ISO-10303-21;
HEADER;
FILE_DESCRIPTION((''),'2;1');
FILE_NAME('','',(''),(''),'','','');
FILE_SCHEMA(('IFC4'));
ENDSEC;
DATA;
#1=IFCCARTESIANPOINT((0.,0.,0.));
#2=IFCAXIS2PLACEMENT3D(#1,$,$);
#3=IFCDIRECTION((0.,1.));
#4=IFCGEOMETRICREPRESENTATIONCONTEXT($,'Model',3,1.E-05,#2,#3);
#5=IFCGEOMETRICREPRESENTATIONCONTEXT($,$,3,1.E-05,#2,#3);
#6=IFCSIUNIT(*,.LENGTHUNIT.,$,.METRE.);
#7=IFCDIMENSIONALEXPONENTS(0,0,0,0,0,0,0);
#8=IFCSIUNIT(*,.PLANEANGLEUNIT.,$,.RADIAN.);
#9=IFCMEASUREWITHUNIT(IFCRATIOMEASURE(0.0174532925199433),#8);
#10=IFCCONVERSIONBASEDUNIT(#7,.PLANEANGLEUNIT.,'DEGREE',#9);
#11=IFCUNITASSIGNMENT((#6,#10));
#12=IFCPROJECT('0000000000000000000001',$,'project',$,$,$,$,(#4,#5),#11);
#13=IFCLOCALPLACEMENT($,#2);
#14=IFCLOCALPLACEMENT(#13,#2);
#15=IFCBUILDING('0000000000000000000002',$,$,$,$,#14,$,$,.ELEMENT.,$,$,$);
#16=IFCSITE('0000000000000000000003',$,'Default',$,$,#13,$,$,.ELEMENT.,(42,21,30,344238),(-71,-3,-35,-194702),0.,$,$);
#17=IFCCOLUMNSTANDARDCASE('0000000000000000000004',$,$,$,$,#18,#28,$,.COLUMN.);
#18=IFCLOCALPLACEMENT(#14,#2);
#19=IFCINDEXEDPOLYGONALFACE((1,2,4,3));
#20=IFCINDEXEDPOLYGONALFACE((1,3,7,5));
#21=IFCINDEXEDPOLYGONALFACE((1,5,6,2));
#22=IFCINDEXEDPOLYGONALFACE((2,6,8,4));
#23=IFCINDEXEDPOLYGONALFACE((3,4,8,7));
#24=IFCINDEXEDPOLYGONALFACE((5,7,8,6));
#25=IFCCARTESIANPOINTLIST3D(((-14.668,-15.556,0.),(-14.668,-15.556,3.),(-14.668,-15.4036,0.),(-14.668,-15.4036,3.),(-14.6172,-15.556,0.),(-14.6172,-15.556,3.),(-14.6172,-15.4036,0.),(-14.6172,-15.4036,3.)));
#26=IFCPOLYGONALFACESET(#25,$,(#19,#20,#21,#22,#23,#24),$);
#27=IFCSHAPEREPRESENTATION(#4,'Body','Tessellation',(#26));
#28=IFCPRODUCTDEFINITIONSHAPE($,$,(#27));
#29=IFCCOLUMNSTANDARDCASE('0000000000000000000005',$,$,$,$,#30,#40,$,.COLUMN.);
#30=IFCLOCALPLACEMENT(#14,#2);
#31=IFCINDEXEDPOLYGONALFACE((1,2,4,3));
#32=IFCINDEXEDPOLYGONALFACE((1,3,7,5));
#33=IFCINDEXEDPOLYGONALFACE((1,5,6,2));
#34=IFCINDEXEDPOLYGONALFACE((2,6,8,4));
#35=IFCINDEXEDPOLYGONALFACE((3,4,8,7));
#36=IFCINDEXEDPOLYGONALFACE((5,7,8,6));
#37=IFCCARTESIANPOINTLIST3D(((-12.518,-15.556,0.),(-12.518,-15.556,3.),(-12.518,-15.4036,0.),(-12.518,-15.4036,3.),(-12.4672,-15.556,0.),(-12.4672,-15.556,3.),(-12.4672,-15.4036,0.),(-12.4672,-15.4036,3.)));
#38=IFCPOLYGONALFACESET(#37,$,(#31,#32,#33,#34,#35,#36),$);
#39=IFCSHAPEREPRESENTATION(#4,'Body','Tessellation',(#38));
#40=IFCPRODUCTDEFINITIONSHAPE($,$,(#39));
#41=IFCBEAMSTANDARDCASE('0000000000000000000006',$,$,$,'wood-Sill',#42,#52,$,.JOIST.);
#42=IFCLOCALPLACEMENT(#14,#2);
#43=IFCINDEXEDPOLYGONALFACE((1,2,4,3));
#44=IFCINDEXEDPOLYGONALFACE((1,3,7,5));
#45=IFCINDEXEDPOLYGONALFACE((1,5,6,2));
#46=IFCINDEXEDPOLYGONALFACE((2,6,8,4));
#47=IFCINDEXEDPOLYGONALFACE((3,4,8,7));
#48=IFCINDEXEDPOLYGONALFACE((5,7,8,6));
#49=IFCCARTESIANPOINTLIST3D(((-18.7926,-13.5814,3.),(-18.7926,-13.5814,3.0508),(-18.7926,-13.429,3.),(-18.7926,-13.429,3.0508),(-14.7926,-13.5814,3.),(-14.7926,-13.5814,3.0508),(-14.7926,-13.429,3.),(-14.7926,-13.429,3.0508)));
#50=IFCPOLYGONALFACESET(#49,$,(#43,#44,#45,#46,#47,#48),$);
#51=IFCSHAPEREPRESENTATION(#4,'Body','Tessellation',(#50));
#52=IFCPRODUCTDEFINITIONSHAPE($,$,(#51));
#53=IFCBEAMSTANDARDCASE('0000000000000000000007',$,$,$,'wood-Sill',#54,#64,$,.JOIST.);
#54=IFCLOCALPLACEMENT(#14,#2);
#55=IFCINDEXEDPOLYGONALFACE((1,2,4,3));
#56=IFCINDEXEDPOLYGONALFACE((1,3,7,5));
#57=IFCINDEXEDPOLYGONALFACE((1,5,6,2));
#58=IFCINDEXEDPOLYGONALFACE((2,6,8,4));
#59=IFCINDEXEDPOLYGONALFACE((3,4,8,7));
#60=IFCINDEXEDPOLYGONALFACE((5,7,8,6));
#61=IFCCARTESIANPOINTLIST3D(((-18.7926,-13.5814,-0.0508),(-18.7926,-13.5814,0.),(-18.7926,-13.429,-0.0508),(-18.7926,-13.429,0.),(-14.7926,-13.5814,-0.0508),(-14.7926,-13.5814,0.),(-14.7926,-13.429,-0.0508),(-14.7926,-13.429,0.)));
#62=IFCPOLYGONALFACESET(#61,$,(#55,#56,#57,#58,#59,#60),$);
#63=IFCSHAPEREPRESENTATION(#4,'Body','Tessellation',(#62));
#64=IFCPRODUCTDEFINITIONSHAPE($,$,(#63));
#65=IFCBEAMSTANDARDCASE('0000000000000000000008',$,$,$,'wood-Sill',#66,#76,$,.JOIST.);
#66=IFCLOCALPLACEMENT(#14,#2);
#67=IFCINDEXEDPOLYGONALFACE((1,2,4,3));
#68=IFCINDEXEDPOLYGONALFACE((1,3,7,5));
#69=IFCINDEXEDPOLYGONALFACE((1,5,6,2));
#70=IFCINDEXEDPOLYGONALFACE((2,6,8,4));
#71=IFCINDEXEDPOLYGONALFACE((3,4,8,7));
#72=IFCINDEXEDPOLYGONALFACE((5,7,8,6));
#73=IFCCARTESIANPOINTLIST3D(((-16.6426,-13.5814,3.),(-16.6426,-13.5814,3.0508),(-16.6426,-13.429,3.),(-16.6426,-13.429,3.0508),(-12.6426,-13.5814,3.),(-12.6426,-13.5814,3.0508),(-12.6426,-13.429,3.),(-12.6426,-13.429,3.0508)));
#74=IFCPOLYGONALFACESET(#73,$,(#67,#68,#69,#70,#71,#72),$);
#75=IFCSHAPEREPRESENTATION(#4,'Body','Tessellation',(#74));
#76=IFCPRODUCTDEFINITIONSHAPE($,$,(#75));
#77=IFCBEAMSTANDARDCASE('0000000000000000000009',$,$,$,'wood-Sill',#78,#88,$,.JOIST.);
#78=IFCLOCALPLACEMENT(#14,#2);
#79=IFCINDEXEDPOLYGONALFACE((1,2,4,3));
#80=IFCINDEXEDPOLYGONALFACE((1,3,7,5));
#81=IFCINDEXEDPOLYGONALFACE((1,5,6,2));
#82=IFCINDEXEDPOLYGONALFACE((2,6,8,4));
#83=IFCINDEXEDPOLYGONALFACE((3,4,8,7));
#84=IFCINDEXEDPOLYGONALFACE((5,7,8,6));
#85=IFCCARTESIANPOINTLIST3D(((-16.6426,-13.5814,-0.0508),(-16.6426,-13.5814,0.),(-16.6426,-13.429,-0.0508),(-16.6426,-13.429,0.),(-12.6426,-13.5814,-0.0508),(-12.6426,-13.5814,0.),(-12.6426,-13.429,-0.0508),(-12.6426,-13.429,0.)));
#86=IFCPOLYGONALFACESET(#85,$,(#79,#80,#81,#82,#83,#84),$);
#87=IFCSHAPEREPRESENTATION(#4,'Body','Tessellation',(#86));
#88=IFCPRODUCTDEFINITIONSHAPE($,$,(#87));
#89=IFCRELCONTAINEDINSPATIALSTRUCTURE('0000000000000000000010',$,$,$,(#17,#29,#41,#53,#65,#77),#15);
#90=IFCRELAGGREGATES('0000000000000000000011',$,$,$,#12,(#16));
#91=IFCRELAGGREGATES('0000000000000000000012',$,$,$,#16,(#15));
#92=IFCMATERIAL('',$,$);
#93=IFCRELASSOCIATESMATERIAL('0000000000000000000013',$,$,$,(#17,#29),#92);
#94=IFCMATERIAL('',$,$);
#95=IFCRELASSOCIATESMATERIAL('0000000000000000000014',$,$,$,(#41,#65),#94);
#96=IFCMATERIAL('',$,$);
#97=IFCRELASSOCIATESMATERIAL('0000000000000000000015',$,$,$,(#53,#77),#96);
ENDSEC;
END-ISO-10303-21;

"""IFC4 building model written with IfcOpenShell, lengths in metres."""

from ifc_helpers import new_model, entity, si_unit, converted_unit, direction, frame, origin, place, context, project, spatial, rectangle, extrude, material, element, save


model = new_model("IFC4")

# Units and contexts
model_context = context("Model", 3, precision=1e-05, world=origin(), true_north=direction((0.0, 1.0)))
context_of_model = context(None, 3, precision=1e-05, world=origin(), true_north=direction((0.0, 1.0)))
ifc_project = project(units=[si_unit("LENGTHUNIT", "METRE"), converted_unit("PLANEANGLEUNIT", "DEGREE", entity("IfcRatioMeasure", 0.0174532925199433), si_unit("PLANEANGLEUNIT", "RADIAN"), dimensions=[0, 0, 0, 0, 0, 0, 0])], contexts=[model_context, context_of_model])

# Site, building
site_placement = place(None, origin())
site = spatial("IfcSite", under=ifc_project, at=site_placement, Name="Default", CompositionType="ELEMENT", RefLatitude=(42, 21, 30, 344238), RefLongitude=(-71, -3, -35, -194702), RefElevation=0.0)
building_placement = place(site_placement, origin())
building = spatial("IfcBuilding", under=site, at=building_placement, CompositionType="ELEMENT")

# Columns
ifc_material_1 = material(Name="")
placement_1 = place(building_placement, origin())
placement_2 = place(placement_1, frame((-14.6426, -15.5052, 0.0), z_axis=(0.0, 0.0, 1.0), x_axis=(0.0, 1.0, 0.0)))
for number, where, z_axis, x_axis in (
    (1, (0.0254, 0.0, 0.0), (0.0, 0.0, 1.0), (0.0, 1.0, 0.0)),
):
    element("IfcColumnStandardCase", number, at=place(placement_2, frame(where, z_axis=z_axis, x_axis=x_axis)), inside=building, material=ifc_material_1, PredefinedType="COLUMN", context=model_context, shape_type="SweptSolid", body=[
        extrude(rectangle(XDim=0.0508, YDim=0.1524), origin(), (0.0, 0.0, 1.0), 3.0),
    ])
placement_3 = place(placement_1, frame((-12.4926, -15.5052, 0.0), z_axis=(0.0, 0.0, 1.0), x_axis=(0.0, 1.0, 0.0)))
for number, where, z_axis, x_axis in (
    (2, (0.0254, 0.0, 0.0), (0.0, 0.0, 1.0), (0.0, 1.0, 0.0)),
):
    element("IfcColumnStandardCase", number, at=place(placement_3, frame(where, z_axis=z_axis, x_axis=x_axis)), inside=building, material=ifc_material_1, PredefinedType="COLUMN", context=model_context, shape_type="SweptSolid", body=[
        extrude(rectangle(XDim=0.0508, YDim=0.1524), origin(), (0.0, 0.0, 1.0), 3.0),
    ])

# Beams
ifc_material_2 = material(Name="")
placement_4 = place(placement_1, frame((-16.7926, -15.5052, 0.0), z_axis=(0.0, 0.0, 1.0), x_axis=(0.0, 1.0, 0.0)))
beam_1_placement = place(placement_4, frame((2.0, 0.0, 3.0), z_axis=(0.0, 0.0, 1.0), x_axis=(0.0, 1.0, 0.0)))
element("IfcBeamStandardCase", 3, at=beam_1_placement, inside=building, material=ifc_material_2, ObjectType="wood-Sill", PredefinedType="JOIST", context=model_context, shape_type="SweptSolid", body=[
    extrude(rectangle(XDim=4.0, YDim=0.1524), origin(), (0.0, 0.0, 1.0), 0.0508),
])
ifc_material_3 = material(Name="")
beam_2_placement = place(placement_4, frame((2.0, 0.0, -0.0508), z_axis=(0.0, 0.0, 1.0), x_axis=(0.0, 1.0, 0.0)))
element("IfcBeamStandardCase", 4, at=beam_2_placement, inside=building, material=ifc_material_3, ObjectType="wood-Sill", PredefinedType="JOIST", context=model_context, shape_type="SweptSolid", body=[
    extrude(rectangle(XDim=4.0, YDim=0.1524), origin(), (0.0, 0.0, 1.0), 0.0508),
])
beam_3_placement = place(placement_2, frame((2.0, 0.0, 3.0), z_axis=(0.0, 0.0, 1.0), x_axis=(0.0, 1.0, 0.0)))
element("IfcBeamStandardCase", 5, at=beam_3_placement, inside=building, material=ifc_material_2, ObjectType="wood-Sill", PredefinedType="JOIST", context=model_context, shape_type="SweptSolid", body=[
    extrude(rectangle(XDim=4.0, YDim=0.1524), origin(), (0.0, 0.0, 1.0), 0.0508),
])
beam_4_placement = place(placement_2, frame((2.0, 0.0, -0.0508), z_axis=(0.0, 0.0, 1.0), x_axis=(0.0, 1.0, 0.0)))
element("IfcBeamStandardCase", 6, at=beam_4_placement, inside=building, material=ifc_material_3, ObjectType="wood-Sill", PredefinedType="JOIST", context=model_context, shape_type="SweptSolid", body=[
    extrude(rectangle(XDim=4.0, YDim=0.1524), origin(), (0.0, 0.0, 1.0), 0.0508),
])

save(model, "model.ifc")
